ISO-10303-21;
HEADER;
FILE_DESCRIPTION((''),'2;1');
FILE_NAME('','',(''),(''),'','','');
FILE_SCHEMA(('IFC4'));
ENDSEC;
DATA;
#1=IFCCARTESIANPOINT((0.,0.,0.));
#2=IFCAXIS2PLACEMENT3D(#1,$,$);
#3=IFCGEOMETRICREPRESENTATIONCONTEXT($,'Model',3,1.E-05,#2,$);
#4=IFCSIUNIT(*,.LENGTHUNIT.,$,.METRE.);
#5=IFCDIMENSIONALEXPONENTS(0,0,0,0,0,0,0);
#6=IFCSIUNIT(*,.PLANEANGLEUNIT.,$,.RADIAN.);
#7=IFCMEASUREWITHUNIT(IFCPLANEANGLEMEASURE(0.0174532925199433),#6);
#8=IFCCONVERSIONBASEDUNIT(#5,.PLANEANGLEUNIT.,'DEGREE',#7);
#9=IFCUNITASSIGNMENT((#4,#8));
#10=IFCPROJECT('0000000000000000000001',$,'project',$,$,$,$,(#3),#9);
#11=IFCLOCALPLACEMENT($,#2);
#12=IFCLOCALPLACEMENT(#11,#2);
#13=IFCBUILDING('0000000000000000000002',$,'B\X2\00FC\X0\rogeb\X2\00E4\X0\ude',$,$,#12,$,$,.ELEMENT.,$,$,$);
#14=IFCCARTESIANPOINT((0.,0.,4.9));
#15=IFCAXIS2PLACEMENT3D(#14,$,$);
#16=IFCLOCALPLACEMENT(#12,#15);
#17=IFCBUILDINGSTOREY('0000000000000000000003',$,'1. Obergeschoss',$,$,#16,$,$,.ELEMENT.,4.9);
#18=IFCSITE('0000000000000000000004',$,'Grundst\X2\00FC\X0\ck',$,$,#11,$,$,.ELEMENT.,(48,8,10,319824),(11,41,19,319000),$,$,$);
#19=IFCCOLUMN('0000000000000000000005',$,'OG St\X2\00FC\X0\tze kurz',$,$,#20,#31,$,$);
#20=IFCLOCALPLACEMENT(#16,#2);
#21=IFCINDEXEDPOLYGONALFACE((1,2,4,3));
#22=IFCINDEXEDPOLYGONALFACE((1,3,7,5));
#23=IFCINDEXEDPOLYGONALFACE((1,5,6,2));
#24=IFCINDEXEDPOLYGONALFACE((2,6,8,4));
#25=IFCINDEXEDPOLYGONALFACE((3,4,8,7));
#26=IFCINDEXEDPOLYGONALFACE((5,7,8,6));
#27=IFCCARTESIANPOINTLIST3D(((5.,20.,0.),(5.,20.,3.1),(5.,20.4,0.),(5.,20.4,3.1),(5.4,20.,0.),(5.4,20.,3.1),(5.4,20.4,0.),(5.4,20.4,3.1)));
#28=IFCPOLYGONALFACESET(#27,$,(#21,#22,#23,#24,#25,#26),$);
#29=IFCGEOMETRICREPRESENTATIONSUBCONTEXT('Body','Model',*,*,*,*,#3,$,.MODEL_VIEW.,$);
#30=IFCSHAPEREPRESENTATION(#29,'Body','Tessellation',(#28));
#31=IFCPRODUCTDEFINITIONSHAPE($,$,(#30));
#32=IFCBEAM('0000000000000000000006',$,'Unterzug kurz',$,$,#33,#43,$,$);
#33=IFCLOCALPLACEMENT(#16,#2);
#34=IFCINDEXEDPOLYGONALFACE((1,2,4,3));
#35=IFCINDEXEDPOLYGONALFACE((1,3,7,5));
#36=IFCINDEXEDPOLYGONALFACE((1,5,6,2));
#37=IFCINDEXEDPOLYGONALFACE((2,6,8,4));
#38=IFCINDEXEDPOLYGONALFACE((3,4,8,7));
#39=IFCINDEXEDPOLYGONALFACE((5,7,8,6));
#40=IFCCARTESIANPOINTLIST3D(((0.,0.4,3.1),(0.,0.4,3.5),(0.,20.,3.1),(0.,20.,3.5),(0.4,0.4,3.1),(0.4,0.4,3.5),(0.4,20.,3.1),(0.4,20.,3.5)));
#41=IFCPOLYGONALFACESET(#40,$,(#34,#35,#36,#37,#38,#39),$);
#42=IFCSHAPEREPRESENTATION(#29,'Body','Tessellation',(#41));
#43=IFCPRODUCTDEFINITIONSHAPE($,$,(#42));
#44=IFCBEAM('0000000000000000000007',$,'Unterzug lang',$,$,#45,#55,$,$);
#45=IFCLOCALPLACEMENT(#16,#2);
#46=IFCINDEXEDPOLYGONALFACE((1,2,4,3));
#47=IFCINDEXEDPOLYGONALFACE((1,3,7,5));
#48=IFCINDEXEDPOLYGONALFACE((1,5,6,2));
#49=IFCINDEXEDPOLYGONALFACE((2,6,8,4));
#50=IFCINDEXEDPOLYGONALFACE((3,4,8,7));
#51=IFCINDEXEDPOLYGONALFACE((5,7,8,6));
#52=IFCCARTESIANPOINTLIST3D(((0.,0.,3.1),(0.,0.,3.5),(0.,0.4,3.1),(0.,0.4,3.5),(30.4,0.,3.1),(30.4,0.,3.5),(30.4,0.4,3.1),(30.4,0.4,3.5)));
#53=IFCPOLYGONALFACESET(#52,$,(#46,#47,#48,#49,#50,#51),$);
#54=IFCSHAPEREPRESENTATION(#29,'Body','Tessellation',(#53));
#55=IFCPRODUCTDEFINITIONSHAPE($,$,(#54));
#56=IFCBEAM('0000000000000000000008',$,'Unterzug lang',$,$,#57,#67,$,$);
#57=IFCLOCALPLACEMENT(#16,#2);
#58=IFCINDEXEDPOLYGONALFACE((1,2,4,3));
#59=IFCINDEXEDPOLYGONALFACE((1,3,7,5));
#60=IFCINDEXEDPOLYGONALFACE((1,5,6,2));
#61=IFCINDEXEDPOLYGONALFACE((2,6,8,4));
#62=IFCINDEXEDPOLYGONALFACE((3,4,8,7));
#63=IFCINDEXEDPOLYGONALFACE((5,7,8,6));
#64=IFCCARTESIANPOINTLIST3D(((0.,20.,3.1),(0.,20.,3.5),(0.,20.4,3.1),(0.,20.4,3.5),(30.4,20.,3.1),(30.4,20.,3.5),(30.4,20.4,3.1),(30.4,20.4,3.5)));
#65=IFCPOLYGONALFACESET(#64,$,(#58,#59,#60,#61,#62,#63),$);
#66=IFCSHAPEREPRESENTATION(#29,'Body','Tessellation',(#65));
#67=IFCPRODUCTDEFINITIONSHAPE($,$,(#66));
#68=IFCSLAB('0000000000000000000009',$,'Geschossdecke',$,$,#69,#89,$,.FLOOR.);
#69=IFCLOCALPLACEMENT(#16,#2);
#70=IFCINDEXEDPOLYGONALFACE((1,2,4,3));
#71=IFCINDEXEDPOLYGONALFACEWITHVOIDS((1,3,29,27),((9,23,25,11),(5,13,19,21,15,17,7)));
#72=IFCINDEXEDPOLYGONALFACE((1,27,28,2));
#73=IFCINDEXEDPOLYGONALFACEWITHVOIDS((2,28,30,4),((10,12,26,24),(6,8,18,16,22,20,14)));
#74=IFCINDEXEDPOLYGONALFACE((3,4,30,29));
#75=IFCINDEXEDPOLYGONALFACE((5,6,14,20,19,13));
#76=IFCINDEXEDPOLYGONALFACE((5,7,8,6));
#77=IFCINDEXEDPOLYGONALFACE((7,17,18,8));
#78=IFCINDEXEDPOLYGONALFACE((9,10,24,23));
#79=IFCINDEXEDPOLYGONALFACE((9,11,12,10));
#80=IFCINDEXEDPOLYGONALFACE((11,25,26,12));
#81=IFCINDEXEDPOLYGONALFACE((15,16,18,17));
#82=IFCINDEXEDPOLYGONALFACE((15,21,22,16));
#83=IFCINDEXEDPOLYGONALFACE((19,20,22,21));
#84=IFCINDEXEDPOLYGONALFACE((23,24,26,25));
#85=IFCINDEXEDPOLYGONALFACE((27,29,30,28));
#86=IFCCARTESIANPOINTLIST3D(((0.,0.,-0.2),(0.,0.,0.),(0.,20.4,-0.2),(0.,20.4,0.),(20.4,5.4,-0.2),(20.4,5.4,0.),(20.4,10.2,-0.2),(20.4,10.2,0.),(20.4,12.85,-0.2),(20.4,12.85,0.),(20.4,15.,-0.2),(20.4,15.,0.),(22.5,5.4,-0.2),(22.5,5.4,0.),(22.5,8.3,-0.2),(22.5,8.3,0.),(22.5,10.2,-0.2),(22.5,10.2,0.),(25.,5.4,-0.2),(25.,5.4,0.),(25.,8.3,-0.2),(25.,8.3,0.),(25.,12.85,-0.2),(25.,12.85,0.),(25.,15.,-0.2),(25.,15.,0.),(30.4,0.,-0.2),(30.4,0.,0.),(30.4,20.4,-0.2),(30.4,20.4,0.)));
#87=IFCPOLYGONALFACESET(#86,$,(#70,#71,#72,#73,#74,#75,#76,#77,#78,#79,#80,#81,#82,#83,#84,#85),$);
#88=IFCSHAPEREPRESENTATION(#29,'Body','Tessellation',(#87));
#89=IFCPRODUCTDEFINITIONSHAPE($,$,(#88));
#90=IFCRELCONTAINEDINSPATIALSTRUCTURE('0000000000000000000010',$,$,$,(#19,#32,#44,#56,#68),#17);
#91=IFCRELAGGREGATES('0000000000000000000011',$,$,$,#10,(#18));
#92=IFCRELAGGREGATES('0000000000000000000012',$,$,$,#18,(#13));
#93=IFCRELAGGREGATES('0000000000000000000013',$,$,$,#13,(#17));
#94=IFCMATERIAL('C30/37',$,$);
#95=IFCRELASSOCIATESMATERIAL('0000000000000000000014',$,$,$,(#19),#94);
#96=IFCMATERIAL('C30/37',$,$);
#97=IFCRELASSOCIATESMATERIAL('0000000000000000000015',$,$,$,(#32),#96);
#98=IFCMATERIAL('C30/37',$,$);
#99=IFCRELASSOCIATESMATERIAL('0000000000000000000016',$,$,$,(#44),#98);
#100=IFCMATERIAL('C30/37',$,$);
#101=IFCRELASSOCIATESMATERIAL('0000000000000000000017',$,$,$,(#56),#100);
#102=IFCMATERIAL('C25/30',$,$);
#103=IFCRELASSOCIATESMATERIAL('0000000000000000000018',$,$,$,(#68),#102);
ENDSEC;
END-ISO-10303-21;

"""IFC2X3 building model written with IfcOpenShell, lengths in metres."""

from ifc_helpers import new_model, entity, si_unit, converted_unit, frame, frame_2d, origin, origin_with_axes, place, context, subcontext, project, spatial, rectangle, extrude, material, element, save


model = new_model("IFC2X3")

# Units and contexts
model_context = context("Model", 3, precision=1e-05, world=origin())
body_context = subcontext(model_context, "Body", "Model", "MODEL_VIEW")
ifc_project = project(units=[si_unit("LENGTHUNIT", "METRE"), converted_unit("PLANEANGLEUNIT", "DEGREE", entity("IfcPlaneAngleMeasure", 0.0174532925199433), si_unit("PLANEANGLEUNIT", "RADIAN"), dimensions=[0, 0, 0, 0, 0, 0, 0])], contexts=[model_context])

# Site, building, storey
site_placement = place(None, origin())
site = spatial("IfcSite", under=ifc_project, at=site_placement, Name="Grundstück", CompositionType="ELEMENT", RefLatitude=(48, 8, 10, 319824), RefLongitude=(11, 41, 19, 319000))
building_placement = place(site_placement, origin())
building = spatial("IfcBuilding", under=site, at=building_placement, Name="Bürogebäude", CompositionType="ELEMENT")
storey_placement = place(building_placement, frame((0.0, 0.0, 4.9)))
storey = spatial("IfcBuildingStorey", under=building, at=storey_placement, Name="1. Obergeschoss", CompositionType="ELEMENT", Elevation=4.9)

# Column
ifc_material_1 = material(Name="C30/37")
column_1_placement = place(storey_placement, frame((5.0, 20.0, 0.0)))
element("IfcColumn", 1, at=column_1_placement, inside=storey, material=ifc_material_1, Name="OG Stütze kurz", context=body_context, shape_type="SweptSolid", body=[
    extrude(rectangle(XDim=0.4, YDim=0.4, at=frame_2d((0.2, 0.2), x_axis=(1.0, 0.0))), origin_with_axes(), (0.0, 0.0, 1.0), 3.1),
])

# Beams
ifc_material_2 = material(Name="C30/37")
beam_1_placement = place(storey_placement, frame((0.0, 20.0, 3.1), z_axis=(0.0, 0.0, 1.0), x_axis=(0.0, -1.0, 0.0)))
element("IfcBeam", 2, at=beam_1_placement, inside=storey, material=ifc_material_2, Name="Unterzug kurz", context=body_context, shape_type="SweptSolid", body=[
    extrude(rectangle(XDim=0.4, YDim=0.4, at=frame_2d((0.2, 0.2), x_axis=(1.0, 0.0))), frame((0.0, 0.0, 0.0), z_axis=(1.0, 0.0, 0.0), x_axis=(0.0, 1.0, 0.0)), (0.0, 0.0, 1.0), 19.6),
])
ifc_material_3 = material(Name="C30/37")
beam_2_placement = place(storey_placement, frame((0.0, 0.0, 3.1), z_axis=(0.0, 0.0, 1.0), x_axis=(1.0, 0.0, 0.0)))
element("IfcBeam", 3, at=beam_2_placement, inside=storey, material=ifc_material_3, Name="Unterzug lang", context=body_context, shape_type="SweptSolid", body=[
    extrude(rectangle(XDim=0.4, YDim=0.4, at=frame_2d((0.2, 0.2), x_axis=(1.0, 0.0))), frame((0.0, 0.0, 0.0), z_axis=(1.0, 0.0, 0.0), x_axis=(0.0, 1.0, 0.0)), (0.0, 0.0, 1.0), 30.4),
])
ifc_material_4 = material(Name="C30/37")
beam_3_placement = place(storey_placement, frame((0.0, 20.0, 3.1)))
element("IfcBeam", 4, at=beam_3_placement, inside=storey, material=ifc_material_4, Name="Unterzug lang", context=body_context, shape_type="SweptSolid", body=[
    extrude(rectangle(XDim=0.4, YDim=0.4, at=frame_2d((0.2, 0.2), x_axis=(1.0, 0.0))), frame((0.0, 0.0, 0.0), z_axis=(1.0, 0.0, 0.0), x_axis=(0.0, 1.0, 0.0)), (0.0, 0.0, 1.0), 30.4),
])

# Slab, openings
ifc_material_5 = material(Name="C25/30")
slab_placement = place(storey_placement, frame((0.0, 0.0, -0.2)))
slab = element("IfcSlab", 5, at=slab_placement, inside=storey, material=ifc_material_5, Name="Geschossdecke", PredefinedType="FLOOR", context=body_context, shape_type="SweptSolid", body=[
    extrude(rectangle(XDim=30.4, YDim=20.4, at=frame_2d((15.2, 10.2), x_axis=(1.0, 0.0))), frame((0.0, 0.0, 0.0), z_axis=(0.0, 0.0, 1.0), x_axis=(1.0, 0.0, 0.0)), (0.0, 0.0, 1.0), 0.2),
])
opening_1_placement = place(slab_placement, frame((22.5, 5.4, 0.0)))
element("IfcOpeningElement", 6, at=opening_1_placement, cuts=slab, ObjectType="Opening", context=body_context, shape_type="SweptSolid", body=[
    extrude(rectangle(XDim=2.9, YDim=2.5, at=frame_2d((0.0, 0.0), x_axis=(0.0, -1.0))), frame((1.25, 1.45, 0.0), z_axis=(0.0, 0.0, 1.0), x_axis=(1.0, 0.0, 0.0)), (0.0, 0.0, 1.0), 0.2),
])
opening_2_placement = place(slab_placement, frame((20.4, 5.4, 0.0)))
element("IfcOpeningElement", 7, at=opening_2_placement, cuts=slab, ObjectType="Opening", context=body_context, shape_type="SweptSolid", body=[
    extrude(rectangle(XDim=2.1, YDim=4.8, at=frame_2d((0.0, 0.0), x_axis=(-1.0, 0.0))), frame((1.05, 2.4, 0.0), z_axis=(0.0, 0.0, 1.0), x_axis=(1.0, 0.0, 0.0)), (0.0, 0.0, 1.0), 0.2),
])
opening_3_placement = place(slab_placement, frame((20.4, 12.85, 0.0)))
element("IfcOpeningElement", 8, at=opening_3_placement, cuts=slab, ObjectType="Opening", context=body_context, shape_type="SweptSolid", body=[
    extrude(rectangle(XDim=2.15, YDim=4.6, at=frame_2d((0.0, 0.0), x_axis=(0.0, -1.0))), frame((2.3, 1.075, 0.0), z_axis=(0.0, 0.0, 1.0), x_axis=(1.0, 0.0, 0.0)), (0.0, 0.0, 1.0), 0.2),
])

save(model, "model.ifc")
